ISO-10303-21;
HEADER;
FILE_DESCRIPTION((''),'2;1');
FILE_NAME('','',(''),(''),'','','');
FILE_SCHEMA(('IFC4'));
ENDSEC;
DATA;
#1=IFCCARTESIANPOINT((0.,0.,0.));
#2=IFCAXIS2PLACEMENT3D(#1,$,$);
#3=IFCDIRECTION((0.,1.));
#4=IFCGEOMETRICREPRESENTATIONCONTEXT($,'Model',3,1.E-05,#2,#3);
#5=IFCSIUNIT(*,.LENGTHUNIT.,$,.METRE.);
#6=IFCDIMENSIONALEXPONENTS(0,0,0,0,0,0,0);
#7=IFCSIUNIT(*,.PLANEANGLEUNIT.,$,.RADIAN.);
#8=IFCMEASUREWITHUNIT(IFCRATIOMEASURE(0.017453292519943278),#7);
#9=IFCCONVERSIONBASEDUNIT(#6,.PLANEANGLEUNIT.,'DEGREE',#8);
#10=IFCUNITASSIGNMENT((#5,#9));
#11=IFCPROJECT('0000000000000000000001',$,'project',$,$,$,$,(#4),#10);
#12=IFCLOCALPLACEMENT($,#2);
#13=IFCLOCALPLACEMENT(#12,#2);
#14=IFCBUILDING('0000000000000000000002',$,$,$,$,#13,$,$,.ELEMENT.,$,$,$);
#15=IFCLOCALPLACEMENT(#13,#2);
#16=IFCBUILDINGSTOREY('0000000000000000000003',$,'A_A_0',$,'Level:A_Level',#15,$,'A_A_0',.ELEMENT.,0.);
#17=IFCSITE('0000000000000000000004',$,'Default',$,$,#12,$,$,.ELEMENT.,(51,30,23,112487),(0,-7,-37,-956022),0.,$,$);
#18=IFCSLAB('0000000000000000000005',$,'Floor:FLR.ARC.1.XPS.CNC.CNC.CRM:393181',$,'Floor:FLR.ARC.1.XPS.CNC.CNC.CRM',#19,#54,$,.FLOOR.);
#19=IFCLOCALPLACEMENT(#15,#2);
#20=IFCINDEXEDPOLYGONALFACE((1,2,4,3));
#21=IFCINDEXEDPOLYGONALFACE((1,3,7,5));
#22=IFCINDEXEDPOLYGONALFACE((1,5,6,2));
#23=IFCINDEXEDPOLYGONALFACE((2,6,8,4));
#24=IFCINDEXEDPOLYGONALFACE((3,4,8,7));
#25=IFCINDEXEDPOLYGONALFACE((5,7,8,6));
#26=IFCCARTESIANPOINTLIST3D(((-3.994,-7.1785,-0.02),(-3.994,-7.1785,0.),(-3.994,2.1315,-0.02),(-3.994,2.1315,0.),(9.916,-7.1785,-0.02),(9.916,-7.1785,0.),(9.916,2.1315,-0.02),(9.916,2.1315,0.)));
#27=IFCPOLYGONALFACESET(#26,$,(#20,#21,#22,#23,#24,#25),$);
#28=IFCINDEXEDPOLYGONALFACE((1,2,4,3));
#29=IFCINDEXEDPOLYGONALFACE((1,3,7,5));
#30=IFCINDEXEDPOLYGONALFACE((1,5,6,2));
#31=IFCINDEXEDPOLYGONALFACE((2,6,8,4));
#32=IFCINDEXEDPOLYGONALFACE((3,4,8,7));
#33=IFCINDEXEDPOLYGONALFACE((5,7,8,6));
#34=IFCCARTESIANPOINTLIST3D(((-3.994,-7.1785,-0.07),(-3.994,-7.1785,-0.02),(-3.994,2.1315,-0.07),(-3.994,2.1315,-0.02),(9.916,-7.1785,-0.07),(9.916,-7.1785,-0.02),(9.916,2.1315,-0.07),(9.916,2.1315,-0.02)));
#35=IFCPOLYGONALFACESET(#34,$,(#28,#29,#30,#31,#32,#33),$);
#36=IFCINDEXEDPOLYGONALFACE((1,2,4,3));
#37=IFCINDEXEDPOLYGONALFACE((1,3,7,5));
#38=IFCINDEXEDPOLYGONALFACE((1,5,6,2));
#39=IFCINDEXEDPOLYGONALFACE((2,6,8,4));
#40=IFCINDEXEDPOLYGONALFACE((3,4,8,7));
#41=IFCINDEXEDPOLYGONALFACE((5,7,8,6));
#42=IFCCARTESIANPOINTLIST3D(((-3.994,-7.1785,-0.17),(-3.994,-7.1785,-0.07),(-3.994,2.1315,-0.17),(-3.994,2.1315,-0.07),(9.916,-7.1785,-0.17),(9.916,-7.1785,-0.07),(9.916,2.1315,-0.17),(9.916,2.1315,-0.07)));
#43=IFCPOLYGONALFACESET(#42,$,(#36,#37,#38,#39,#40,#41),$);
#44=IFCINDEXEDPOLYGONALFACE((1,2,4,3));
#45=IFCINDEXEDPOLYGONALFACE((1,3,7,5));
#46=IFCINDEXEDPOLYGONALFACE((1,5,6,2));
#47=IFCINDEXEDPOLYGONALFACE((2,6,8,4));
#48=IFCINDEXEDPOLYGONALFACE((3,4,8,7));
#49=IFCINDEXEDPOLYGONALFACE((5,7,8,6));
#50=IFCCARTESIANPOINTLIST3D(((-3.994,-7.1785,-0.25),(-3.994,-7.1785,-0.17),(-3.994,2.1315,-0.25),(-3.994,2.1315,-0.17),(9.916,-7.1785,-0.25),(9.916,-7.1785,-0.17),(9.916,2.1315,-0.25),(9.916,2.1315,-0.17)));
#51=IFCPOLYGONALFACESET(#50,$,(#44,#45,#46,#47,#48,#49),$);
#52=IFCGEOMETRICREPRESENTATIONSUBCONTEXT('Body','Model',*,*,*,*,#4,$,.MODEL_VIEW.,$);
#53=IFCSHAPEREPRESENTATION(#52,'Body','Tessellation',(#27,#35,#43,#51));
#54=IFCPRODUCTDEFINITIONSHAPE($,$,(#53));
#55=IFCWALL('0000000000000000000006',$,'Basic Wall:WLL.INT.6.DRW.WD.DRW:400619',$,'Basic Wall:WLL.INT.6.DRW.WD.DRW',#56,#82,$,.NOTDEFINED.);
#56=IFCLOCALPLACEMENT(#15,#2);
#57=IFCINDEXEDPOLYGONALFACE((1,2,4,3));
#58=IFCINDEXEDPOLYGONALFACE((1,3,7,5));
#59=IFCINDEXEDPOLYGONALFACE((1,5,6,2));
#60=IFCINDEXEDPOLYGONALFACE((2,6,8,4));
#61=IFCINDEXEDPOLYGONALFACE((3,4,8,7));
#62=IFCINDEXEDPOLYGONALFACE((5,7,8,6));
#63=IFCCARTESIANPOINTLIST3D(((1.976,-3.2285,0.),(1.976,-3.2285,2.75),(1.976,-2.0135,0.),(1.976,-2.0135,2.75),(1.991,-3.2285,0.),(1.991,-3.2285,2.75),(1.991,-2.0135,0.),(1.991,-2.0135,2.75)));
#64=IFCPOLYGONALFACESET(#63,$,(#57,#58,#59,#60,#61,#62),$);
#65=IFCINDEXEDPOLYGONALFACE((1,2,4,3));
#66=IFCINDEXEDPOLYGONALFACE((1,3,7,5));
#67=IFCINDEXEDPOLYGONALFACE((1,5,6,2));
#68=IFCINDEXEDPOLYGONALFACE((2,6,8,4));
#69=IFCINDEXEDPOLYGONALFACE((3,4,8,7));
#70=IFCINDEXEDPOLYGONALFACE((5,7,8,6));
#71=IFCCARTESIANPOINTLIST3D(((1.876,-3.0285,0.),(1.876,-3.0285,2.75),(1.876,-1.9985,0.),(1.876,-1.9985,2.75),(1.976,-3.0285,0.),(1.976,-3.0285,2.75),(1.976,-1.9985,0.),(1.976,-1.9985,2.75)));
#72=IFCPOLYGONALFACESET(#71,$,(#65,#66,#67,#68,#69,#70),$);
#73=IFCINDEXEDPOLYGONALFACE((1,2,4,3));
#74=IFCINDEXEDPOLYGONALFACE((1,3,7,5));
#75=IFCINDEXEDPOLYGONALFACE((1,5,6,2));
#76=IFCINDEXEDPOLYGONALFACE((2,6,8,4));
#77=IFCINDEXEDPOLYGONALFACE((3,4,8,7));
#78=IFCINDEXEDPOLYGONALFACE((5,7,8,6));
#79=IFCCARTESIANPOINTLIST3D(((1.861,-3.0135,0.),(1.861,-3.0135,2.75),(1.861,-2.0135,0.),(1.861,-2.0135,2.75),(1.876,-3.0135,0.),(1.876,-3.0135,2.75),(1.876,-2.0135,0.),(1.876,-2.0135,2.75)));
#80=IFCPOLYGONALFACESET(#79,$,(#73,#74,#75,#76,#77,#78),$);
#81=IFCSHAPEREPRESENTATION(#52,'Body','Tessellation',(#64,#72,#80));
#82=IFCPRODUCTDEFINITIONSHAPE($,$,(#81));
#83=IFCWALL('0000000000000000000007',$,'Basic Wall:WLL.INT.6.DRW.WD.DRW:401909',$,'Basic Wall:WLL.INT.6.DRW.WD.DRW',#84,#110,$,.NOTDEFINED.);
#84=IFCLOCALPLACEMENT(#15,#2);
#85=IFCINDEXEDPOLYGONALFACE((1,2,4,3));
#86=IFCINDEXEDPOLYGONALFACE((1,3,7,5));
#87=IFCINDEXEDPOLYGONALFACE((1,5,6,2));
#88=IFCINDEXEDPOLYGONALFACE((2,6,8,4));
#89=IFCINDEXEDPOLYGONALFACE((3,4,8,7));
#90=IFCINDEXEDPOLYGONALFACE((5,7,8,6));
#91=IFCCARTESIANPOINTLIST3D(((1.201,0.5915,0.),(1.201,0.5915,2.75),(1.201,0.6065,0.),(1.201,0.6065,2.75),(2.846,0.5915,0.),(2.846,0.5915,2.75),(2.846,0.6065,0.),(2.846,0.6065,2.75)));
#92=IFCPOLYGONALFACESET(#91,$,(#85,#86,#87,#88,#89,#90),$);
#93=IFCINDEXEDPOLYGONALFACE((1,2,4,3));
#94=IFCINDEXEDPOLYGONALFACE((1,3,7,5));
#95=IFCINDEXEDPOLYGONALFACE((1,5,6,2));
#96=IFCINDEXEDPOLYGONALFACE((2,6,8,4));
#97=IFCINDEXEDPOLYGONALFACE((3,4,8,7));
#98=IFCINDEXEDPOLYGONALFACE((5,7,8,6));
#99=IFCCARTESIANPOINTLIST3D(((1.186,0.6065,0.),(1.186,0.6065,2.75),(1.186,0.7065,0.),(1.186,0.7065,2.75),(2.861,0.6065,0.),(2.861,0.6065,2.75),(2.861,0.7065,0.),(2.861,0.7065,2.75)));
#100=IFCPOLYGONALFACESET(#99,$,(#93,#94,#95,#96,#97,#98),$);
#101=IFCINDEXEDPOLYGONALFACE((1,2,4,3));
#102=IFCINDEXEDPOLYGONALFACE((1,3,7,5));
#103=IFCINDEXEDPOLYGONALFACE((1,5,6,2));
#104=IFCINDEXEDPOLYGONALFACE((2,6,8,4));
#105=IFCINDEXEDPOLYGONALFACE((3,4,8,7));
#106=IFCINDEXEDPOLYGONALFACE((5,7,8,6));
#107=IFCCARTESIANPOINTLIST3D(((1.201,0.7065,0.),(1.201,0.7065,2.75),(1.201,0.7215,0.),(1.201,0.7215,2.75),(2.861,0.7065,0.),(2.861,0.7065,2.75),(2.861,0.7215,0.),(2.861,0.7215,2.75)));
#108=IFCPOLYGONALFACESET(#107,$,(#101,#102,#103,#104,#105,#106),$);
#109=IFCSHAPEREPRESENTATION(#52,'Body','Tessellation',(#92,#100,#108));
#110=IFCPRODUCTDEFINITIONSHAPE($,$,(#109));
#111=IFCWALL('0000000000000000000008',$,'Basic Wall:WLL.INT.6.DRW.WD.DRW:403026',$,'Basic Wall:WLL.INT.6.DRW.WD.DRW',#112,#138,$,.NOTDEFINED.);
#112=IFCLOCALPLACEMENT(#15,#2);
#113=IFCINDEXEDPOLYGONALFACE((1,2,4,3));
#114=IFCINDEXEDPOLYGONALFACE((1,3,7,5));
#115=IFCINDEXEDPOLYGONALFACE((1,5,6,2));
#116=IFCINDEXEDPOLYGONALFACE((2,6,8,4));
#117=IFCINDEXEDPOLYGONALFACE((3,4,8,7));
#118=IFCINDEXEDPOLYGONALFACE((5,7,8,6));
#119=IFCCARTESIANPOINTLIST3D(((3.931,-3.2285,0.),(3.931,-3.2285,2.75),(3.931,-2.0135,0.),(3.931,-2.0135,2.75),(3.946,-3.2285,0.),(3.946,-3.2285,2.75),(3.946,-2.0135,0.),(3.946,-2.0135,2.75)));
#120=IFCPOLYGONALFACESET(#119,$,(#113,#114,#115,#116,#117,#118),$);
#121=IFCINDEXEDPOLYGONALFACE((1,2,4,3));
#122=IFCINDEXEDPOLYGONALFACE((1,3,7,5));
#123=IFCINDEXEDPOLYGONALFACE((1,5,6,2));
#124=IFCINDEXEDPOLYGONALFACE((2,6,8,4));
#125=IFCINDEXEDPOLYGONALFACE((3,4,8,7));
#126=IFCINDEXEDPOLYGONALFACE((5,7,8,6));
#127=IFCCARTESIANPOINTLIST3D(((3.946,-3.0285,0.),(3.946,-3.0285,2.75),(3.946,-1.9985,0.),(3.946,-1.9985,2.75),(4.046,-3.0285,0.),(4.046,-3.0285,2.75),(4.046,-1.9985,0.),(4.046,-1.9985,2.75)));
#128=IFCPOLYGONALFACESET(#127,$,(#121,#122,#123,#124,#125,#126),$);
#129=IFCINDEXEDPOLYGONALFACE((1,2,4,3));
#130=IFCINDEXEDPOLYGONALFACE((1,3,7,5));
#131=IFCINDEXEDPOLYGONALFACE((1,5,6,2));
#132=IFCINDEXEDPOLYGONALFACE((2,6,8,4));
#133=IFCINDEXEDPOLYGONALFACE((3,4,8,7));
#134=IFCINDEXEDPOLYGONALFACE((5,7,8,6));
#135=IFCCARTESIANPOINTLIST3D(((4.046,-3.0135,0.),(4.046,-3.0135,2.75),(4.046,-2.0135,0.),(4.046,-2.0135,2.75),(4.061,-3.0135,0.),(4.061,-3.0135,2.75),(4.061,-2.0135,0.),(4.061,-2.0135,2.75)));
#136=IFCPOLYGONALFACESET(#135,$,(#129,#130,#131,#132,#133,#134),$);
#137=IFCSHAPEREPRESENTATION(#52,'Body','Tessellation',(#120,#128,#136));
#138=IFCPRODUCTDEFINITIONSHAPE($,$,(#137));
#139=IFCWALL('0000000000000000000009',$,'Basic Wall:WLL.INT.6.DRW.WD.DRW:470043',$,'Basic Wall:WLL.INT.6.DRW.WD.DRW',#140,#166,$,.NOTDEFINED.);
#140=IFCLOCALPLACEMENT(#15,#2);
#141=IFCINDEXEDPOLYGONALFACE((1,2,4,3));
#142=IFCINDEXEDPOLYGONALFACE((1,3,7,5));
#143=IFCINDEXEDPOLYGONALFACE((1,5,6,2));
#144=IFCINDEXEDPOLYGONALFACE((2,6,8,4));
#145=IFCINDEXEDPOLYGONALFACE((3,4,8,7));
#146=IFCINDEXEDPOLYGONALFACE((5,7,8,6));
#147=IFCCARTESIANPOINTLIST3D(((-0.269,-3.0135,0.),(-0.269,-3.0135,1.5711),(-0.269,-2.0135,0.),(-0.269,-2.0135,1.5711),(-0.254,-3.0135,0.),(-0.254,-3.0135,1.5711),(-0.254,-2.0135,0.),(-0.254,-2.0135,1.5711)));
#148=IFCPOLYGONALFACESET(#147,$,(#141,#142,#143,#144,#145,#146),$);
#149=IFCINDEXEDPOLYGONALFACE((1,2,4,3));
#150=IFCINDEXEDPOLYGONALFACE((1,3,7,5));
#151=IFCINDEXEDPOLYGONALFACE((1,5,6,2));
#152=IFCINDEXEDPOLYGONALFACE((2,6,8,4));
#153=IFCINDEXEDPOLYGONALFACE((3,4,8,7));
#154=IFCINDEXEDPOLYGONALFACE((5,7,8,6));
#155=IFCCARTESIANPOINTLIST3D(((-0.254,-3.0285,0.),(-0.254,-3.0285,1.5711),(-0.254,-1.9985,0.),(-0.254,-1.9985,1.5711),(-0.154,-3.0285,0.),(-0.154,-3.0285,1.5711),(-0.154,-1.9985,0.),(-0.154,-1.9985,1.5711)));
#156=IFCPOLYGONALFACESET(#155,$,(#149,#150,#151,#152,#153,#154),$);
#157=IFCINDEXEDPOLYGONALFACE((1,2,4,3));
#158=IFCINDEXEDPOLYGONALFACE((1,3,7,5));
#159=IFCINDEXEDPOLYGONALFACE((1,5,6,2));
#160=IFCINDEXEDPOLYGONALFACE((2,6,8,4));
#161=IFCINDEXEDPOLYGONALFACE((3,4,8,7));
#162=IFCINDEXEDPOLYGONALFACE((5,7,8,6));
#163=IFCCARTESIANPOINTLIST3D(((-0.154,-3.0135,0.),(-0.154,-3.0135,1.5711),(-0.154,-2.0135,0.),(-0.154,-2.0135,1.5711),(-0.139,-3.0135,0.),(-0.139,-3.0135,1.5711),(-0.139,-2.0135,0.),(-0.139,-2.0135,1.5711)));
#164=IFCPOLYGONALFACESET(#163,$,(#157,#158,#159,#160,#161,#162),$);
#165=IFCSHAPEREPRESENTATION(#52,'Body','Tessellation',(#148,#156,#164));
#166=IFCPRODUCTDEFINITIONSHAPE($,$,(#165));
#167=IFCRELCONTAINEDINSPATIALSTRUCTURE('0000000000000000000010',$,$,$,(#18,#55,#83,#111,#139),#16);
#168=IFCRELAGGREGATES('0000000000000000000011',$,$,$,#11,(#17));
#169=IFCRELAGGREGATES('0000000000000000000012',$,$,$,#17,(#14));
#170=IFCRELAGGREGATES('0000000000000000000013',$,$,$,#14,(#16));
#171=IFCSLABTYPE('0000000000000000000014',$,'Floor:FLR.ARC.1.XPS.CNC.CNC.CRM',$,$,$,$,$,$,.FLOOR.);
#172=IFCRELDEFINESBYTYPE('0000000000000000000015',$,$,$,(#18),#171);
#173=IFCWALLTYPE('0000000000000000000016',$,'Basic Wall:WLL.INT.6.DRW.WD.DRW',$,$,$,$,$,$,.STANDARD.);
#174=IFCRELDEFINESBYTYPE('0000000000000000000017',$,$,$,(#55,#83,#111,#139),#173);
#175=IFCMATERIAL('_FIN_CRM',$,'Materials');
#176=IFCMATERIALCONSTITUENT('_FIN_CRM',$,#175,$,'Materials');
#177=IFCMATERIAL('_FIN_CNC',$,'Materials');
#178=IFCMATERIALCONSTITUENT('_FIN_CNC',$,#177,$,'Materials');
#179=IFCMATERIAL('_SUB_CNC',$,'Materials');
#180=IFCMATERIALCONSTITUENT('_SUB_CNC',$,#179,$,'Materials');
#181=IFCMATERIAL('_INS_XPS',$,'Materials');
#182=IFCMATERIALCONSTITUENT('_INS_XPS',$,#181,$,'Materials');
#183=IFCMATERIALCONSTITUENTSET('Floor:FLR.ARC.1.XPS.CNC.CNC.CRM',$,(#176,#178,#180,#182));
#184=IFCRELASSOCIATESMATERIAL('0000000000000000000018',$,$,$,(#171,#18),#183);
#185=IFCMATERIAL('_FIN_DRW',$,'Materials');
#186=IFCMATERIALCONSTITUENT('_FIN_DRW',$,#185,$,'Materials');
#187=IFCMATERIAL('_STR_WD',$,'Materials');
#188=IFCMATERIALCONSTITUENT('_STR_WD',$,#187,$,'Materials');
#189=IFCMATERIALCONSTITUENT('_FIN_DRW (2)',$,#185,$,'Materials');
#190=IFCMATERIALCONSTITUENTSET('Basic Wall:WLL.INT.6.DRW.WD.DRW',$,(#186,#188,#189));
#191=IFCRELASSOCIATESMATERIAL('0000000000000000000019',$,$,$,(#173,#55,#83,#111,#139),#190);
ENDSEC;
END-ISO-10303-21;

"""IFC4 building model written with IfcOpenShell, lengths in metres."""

from ifc_helpers import new_model, entity, si_unit, converted_unit, direction, frame, origin, place, context, subcontext, project, spatial, indexed_curve, outline, extrude, material, constituent, constituent_set, type_object, element, save


model = new_model("IFC4")

# Units and contexts
model_context = context("Model", 3, precision=1e-05, world=origin(), true_north=direction((0.0, 1.0)))
body_context = subcontext(model_context, "Body", "Model", "MODEL_VIEW")
ifc_project = project(units=[si_unit("LENGTHUNIT", "METRE"), converted_unit("PLANEANGLEUNIT", "DEGREE", entity("IfcRatioMeasure", 0.017453292519943278), si_unit("PLANEANGLEUNIT", "RADIAN"), dimensions=[0, 0, 0, 0, 0, 0, 0])], contexts=[model_context])

# Site, building, storey
site_placement = place(None, origin())
site = spatial("IfcSite", under=ifc_project, at=site_placement, Name="Default", CompositionType="ELEMENT", RefLatitude=(51, 30, 23, 112487), RefLongitude=(0, -7, -37, -956022), RefElevation=0.0)
building_placement = place(site_placement, origin())
building = spatial("IfcBuilding", under=site, at=building_placement, CompositionType="ELEMENT")
storey_placement = place(building_placement, origin())
storey = spatial("IfcBuildingStorey", under=building, at=storey_placement, Name="A_A_0", ObjectType="Level:A_Level", LongName="A_A_0", CompositionType="ELEMENT", Elevation=0.0)

# Slab
ifc_material_1 = material(Name="_FIN_CRM", Category="Materials")
ifc_constituent_1 = constituent(ifc_material_1, Name="_FIN_CRM", Category="Materials")
ifc_material_2 = material(Name="_FIN_CNC", Category="Materials")
ifc_constituent_2 = constituent(ifc_material_2, Name="_FIN_CNC", Category="Materials")
ifc_material_3 = material(Name="_SUB_CNC", Category="Materials")
ifc_constituent_3 = constituent(ifc_material_3, Name="_SUB_CNC", Category="Materials")
ifc_material_4 = material(Name="_INS_XPS", Category="Materials")
ifc_constituent_4 = constituent(ifc_material_4, Name="_INS_XPS", Category="Materials")
ifc_constituent_set_1 = constituent_set(constituents=[ifc_constituent_1, ifc_constituent_2, ifc_constituent_3, ifc_constituent_4], Name="Floor:FLR.ARC.1.XPS.CNC.CNC.CRM")
slab_type = type_object("IfcSlabType", Name="Floor:FLR.ARC.1.XPS.CNC.CNC.CRM", PredefinedType="FLOOR", material=ifc_constituent_set_1)
slab_placement = place(storey_placement, origin())
element("IfcSlab", 1, at=slab_placement, inside=storey, type_object=slab_type, material=ifc_constituent_set_1, Name="Floor:FLR.ARC.1.XPS.CNC.CNC.CRM:393181", ObjectType="Floor:FLR.ARC.1.XPS.CNC.CNC.CRM", PredefinedType="FLOOR", context=body_context, shape_type="SweptSolid", body=[
    extrude(outline(indexed_curve([(-6.955, -4.655), (6.955, -4.655), (6.955, 4.655), (-6.955, 4.655), (-6.955, -4.655)], self_intersect=False)), frame((2.961, -2.5235, -0.02), z_axis=(0.0, 0.0, 1.0), x_axis=(-1.0, 0.0, 0.0)), (0.0, 0.0, 1.0), 0.02),
    extrude(outline(indexed_curve([(-6.955, -4.655), (6.955, -4.655), (6.955, 4.655), (-6.955, 4.655), (-6.955, -4.655)], self_intersect=False)), frame((2.961, -2.5235, -0.07), z_axis=(0.0, 0.0, 1.0), x_axis=(-1.0, 0.0, 0.0)), (0.0, 0.0, 1.0), 0.05),
    extrude(outline(indexed_curve([(-6.955, -4.655), (6.955, -4.655), (6.955, 4.655), (-6.955, 4.655), (-6.955, -4.655)], self_intersect=False)), frame((2.961, -2.5235, -0.17), z_axis=(0.0, 0.0, 1.0), x_axis=(-1.0, 0.0, 0.0)), (0.0, 0.0, 1.0), 0.1),
    extrude(outline(indexed_curve([(-6.955, -4.655), (6.955, -4.655), (6.955, 4.655), (-6.955, 4.655), (-6.955, -4.655)], self_intersect=False)), frame((2.961, -2.5235, -0.25), z_axis=(0.0, 0.0, 1.0), x_axis=(-1.0, 0.0, 0.0)), (0.0, 0.0, 1.0), 0.08),
])

# Shared definitions
ifc_material_5 = material(Name="_FIN_DRW", Category="Materials")
ifc_material_6 = material(Name="_STR_WD", Category="Materials")

# Walls
ifc_constituent_5 = constituent(ifc_material_5, Name="_FIN_DRW", Category="Materials")
ifc_constituent_6 = constituent(ifc_material_6, Name="_STR_WD", Category="Materials")
ifc_constituent_7 = constituent(ifc_material_5, Name="_FIN_DRW (2)", Category="Materials")
ifc_constituent_set_2 = constituent_set(constituents=[ifc_constituent_5, ifc_constituent_6, ifc_constituent_7], Name="Basic Wall:WLL.INT.6.DRW.WD.DRW")
wall_type_1 = type_object("IfcWallType", Name="Basic Wall:WLL.INT.6.DRW.WD.DRW", PredefinedType="STANDARD", material=ifc_constituent_set_2)
wall_1_placement = place(storey_placement, frame((1.926, -2.0135, 0.0), z_axis=(0.0, 0.0, 1.0), x_axis=(0.0, -1.0, 0.0)))
element("IfcWall", 2, at=wall_1_placement, inside=storey, type_object=wall_type_1, material=ifc_constituent_set_2, Name="Basic Wall:WLL.INT.6.DRW.WD.DRW:400619", ObjectType="Basic Wall:WLL.INT.6.DRW.WD.DRW", PredefinedType="NOTDEFINED", context=body_context, shape_type="SweptSolid", body=[
    extrude(outline(indexed_curve([(-0.0075, -0.6075), (0.0075, -0.6075), (0.0075, 0.6075), (-0.0075, 0.6075), (-0.0075, -0.6075)], self_intersect=False)), frame((0.6075, 0.0575, 0.0), z_axis=(0.0, 0.0, 1.0), x_axis=(0.0, -1.0, 0.0)), (0.0, 0.0, 1.0), 2.75),
    extrude(outline(indexed_curve([(-0.515, -0.05), (0.515, -0.05), (0.515, 0.05), (-0.515, 0.05), (-0.515, -0.05)], self_intersect=False)), frame((0.5, 0.0, 0.0)), (0.0, 0.0, 1.0), 2.75),
    extrude(outline(indexed_curve([(-0.0075, -0.5), (0.0075, -0.5), (0.0075, 0.5), (-0.0075, 0.5), (-0.0075, -0.5)], self_intersect=False)), frame((0.5, -0.0575, 0.0), z_axis=(0.0, 0.0, 1.0), x_axis=(0.0, 1.0, 0.0)), (0.0, 0.0, 1.0), 2.75),
])
wall_2_placement = place(storey_placement, frame((1.201, 0.6565, 0.0)))
element("IfcWall", 3, at=wall_2_placement, inside=storey, type_object=wall_type_1, material=ifc_constituent_set_2, Name="Basic Wall:WLL.INT.6.DRW.WD.DRW:401909", ObjectType="Basic Wall:WLL.INT.6.DRW.WD.DRW", PredefinedType="NOTDEFINED", context=body_context, shape_type="SweptSolid", body=[
    extrude(outline(indexed_curve([(-0.0075, -0.8225), (0.0075, -0.8225), (0.0075, 0.8225), (-0.0075, 0.8225), (-0.0075, -0.8225)], self_intersect=False)), frame((0.8225, -0.0575, 0.0), z_axis=(0.0, 0.0, 1.0), x_axis=(0.0, 1.0, 0.0)), (0.0, 0.0, 1.0), 2.75),
    extrude(outline(indexed_curve([(-0.8375, -0.05), (0.8375, -0.05), (0.8375, 0.05), (-0.8375, 0.05), (-0.8375, -0.05)], self_intersect=False)), frame((0.8225, 0.0, 0.0)), (0.0, 0.0, 1.0), 2.75),
    extrude(outline(indexed_curve([(-0.0075, -0.83), (0.0075, -0.83), (0.0075, 0.83), (-0.0075, 0.83), (-0.0075, -0.83)], self_intersect=False)), frame((0.83, 0.0575, 0.0), z_axis=(0.0, 0.0, 1.0), x_axis=(0.0, -1.0, 0.0)), (0.0, 0.0, 1.0), 2.75),
])
wall_3_placement = place(storey_placement, frame((3.996, -2.0135, 0.0), z_axis=(0.0, 0.0, 1.0), x_axis=(0.0, -1.0, 0.0)))
element("IfcWall", 4, at=wall_3_placement, inside=storey, type_object=wall_type_1, material=ifc_constituent_set_2, Name="Basic Wall:WLL.INT.6.DRW.WD.DRW:403026", ObjectType="Basic Wall:WLL.INT.6.DRW.WD.DRW", PredefinedType="NOTDEFINED", context=body_context, shape_type="SweptSolid", body=[
    extrude(outline(indexed_curve([(-0.0075, -0.6075), (0.0075, -0.6075), (0.0075, 0.6075), (-0.0075, 0.6075), (-0.0075, -0.6075)], self_intersect=False)), frame((0.6075, -0.0575, 0.0), z_axis=(0.0, 0.0, 1.0), x_axis=(0.0, 1.0, 0.0)), (0.0, 0.0, 1.0), 2.75),
    extrude(outline(indexed_curve([(-0.515, -0.05), (0.515, -0.05), (0.515, 0.05), (-0.515, 0.05), (-0.515, -0.05)], self_intersect=False)), frame((0.5, 0.0, 0.0)), (0.0, 0.0, 1.0), 2.75),
    extrude(outline(indexed_curve([(-0.0075, -0.5), (0.0075, -0.5), (0.0075, 0.5), (-0.0075, 0.5), (-0.0075, -0.5)], self_intersect=False)), frame((0.5, 0.0575, 0.0), z_axis=(0.0, 0.0, 1.0), x_axis=(0.0, -1.0, 0.0)), (0.0, 0.0, 1.0), 2.75),
])
wall_4_placement = place(storey_placement, frame((-0.204, -2.0135, 0.0), z_axis=(0.0, 0.0, 1.0), x_axis=(0.0, -1.0, 0.0)))
element("IfcWall", 5, at=wall_4_placement, inside=storey, type_object=wall_type_1, material=ifc_constituent_set_2, Name="Basic Wall:WLL.INT.6.DRW.WD.DRW:470043", ObjectType="Basic Wall:WLL.INT.6.DRW.WD.DRW", PredefinedType="NOTDEFINED", context=body_context, shape_type="SweptSolid", body=[
    extrude(outline(indexed_curve([(-0.0075, -0.5), (0.0075, -0.5), (0.0075, 0.5), (-0.0075, 0.5), (-0.0075, -0.5)], self_intersect=False)), frame((0.5, -0.0575, 0.0), z_axis=(0.0, 0.0, 1.0), x_axis=(0.0, 1.0, 0.0)), (0.0, 0.0, 1.0), 1.5711),
    extrude(outline(indexed_curve([(-0.515, -0.05), (0.515, -0.05), (0.515, 0.05), (-0.515, 0.05), (-0.515, -0.05)], self_intersect=False)), frame((0.5, 0.0, 0.0)), (0.0, 0.0, 1.0), 1.5711),
    extrude(outline(indexed_curve([(-0.0075, -0.5), (0.0075, -0.5), (0.0075, 0.5), (-0.0075, 0.5), (-0.0075, -0.5)], self_intersect=False)), frame((0.5, 0.0575, 0.0), z_axis=(0.0, 0.0, 1.0), x_axis=(0.0, -1.0, 0.0)), (0.0, 0.0, 1.0), 1.5711),
])

save(model, "model.ifc")
